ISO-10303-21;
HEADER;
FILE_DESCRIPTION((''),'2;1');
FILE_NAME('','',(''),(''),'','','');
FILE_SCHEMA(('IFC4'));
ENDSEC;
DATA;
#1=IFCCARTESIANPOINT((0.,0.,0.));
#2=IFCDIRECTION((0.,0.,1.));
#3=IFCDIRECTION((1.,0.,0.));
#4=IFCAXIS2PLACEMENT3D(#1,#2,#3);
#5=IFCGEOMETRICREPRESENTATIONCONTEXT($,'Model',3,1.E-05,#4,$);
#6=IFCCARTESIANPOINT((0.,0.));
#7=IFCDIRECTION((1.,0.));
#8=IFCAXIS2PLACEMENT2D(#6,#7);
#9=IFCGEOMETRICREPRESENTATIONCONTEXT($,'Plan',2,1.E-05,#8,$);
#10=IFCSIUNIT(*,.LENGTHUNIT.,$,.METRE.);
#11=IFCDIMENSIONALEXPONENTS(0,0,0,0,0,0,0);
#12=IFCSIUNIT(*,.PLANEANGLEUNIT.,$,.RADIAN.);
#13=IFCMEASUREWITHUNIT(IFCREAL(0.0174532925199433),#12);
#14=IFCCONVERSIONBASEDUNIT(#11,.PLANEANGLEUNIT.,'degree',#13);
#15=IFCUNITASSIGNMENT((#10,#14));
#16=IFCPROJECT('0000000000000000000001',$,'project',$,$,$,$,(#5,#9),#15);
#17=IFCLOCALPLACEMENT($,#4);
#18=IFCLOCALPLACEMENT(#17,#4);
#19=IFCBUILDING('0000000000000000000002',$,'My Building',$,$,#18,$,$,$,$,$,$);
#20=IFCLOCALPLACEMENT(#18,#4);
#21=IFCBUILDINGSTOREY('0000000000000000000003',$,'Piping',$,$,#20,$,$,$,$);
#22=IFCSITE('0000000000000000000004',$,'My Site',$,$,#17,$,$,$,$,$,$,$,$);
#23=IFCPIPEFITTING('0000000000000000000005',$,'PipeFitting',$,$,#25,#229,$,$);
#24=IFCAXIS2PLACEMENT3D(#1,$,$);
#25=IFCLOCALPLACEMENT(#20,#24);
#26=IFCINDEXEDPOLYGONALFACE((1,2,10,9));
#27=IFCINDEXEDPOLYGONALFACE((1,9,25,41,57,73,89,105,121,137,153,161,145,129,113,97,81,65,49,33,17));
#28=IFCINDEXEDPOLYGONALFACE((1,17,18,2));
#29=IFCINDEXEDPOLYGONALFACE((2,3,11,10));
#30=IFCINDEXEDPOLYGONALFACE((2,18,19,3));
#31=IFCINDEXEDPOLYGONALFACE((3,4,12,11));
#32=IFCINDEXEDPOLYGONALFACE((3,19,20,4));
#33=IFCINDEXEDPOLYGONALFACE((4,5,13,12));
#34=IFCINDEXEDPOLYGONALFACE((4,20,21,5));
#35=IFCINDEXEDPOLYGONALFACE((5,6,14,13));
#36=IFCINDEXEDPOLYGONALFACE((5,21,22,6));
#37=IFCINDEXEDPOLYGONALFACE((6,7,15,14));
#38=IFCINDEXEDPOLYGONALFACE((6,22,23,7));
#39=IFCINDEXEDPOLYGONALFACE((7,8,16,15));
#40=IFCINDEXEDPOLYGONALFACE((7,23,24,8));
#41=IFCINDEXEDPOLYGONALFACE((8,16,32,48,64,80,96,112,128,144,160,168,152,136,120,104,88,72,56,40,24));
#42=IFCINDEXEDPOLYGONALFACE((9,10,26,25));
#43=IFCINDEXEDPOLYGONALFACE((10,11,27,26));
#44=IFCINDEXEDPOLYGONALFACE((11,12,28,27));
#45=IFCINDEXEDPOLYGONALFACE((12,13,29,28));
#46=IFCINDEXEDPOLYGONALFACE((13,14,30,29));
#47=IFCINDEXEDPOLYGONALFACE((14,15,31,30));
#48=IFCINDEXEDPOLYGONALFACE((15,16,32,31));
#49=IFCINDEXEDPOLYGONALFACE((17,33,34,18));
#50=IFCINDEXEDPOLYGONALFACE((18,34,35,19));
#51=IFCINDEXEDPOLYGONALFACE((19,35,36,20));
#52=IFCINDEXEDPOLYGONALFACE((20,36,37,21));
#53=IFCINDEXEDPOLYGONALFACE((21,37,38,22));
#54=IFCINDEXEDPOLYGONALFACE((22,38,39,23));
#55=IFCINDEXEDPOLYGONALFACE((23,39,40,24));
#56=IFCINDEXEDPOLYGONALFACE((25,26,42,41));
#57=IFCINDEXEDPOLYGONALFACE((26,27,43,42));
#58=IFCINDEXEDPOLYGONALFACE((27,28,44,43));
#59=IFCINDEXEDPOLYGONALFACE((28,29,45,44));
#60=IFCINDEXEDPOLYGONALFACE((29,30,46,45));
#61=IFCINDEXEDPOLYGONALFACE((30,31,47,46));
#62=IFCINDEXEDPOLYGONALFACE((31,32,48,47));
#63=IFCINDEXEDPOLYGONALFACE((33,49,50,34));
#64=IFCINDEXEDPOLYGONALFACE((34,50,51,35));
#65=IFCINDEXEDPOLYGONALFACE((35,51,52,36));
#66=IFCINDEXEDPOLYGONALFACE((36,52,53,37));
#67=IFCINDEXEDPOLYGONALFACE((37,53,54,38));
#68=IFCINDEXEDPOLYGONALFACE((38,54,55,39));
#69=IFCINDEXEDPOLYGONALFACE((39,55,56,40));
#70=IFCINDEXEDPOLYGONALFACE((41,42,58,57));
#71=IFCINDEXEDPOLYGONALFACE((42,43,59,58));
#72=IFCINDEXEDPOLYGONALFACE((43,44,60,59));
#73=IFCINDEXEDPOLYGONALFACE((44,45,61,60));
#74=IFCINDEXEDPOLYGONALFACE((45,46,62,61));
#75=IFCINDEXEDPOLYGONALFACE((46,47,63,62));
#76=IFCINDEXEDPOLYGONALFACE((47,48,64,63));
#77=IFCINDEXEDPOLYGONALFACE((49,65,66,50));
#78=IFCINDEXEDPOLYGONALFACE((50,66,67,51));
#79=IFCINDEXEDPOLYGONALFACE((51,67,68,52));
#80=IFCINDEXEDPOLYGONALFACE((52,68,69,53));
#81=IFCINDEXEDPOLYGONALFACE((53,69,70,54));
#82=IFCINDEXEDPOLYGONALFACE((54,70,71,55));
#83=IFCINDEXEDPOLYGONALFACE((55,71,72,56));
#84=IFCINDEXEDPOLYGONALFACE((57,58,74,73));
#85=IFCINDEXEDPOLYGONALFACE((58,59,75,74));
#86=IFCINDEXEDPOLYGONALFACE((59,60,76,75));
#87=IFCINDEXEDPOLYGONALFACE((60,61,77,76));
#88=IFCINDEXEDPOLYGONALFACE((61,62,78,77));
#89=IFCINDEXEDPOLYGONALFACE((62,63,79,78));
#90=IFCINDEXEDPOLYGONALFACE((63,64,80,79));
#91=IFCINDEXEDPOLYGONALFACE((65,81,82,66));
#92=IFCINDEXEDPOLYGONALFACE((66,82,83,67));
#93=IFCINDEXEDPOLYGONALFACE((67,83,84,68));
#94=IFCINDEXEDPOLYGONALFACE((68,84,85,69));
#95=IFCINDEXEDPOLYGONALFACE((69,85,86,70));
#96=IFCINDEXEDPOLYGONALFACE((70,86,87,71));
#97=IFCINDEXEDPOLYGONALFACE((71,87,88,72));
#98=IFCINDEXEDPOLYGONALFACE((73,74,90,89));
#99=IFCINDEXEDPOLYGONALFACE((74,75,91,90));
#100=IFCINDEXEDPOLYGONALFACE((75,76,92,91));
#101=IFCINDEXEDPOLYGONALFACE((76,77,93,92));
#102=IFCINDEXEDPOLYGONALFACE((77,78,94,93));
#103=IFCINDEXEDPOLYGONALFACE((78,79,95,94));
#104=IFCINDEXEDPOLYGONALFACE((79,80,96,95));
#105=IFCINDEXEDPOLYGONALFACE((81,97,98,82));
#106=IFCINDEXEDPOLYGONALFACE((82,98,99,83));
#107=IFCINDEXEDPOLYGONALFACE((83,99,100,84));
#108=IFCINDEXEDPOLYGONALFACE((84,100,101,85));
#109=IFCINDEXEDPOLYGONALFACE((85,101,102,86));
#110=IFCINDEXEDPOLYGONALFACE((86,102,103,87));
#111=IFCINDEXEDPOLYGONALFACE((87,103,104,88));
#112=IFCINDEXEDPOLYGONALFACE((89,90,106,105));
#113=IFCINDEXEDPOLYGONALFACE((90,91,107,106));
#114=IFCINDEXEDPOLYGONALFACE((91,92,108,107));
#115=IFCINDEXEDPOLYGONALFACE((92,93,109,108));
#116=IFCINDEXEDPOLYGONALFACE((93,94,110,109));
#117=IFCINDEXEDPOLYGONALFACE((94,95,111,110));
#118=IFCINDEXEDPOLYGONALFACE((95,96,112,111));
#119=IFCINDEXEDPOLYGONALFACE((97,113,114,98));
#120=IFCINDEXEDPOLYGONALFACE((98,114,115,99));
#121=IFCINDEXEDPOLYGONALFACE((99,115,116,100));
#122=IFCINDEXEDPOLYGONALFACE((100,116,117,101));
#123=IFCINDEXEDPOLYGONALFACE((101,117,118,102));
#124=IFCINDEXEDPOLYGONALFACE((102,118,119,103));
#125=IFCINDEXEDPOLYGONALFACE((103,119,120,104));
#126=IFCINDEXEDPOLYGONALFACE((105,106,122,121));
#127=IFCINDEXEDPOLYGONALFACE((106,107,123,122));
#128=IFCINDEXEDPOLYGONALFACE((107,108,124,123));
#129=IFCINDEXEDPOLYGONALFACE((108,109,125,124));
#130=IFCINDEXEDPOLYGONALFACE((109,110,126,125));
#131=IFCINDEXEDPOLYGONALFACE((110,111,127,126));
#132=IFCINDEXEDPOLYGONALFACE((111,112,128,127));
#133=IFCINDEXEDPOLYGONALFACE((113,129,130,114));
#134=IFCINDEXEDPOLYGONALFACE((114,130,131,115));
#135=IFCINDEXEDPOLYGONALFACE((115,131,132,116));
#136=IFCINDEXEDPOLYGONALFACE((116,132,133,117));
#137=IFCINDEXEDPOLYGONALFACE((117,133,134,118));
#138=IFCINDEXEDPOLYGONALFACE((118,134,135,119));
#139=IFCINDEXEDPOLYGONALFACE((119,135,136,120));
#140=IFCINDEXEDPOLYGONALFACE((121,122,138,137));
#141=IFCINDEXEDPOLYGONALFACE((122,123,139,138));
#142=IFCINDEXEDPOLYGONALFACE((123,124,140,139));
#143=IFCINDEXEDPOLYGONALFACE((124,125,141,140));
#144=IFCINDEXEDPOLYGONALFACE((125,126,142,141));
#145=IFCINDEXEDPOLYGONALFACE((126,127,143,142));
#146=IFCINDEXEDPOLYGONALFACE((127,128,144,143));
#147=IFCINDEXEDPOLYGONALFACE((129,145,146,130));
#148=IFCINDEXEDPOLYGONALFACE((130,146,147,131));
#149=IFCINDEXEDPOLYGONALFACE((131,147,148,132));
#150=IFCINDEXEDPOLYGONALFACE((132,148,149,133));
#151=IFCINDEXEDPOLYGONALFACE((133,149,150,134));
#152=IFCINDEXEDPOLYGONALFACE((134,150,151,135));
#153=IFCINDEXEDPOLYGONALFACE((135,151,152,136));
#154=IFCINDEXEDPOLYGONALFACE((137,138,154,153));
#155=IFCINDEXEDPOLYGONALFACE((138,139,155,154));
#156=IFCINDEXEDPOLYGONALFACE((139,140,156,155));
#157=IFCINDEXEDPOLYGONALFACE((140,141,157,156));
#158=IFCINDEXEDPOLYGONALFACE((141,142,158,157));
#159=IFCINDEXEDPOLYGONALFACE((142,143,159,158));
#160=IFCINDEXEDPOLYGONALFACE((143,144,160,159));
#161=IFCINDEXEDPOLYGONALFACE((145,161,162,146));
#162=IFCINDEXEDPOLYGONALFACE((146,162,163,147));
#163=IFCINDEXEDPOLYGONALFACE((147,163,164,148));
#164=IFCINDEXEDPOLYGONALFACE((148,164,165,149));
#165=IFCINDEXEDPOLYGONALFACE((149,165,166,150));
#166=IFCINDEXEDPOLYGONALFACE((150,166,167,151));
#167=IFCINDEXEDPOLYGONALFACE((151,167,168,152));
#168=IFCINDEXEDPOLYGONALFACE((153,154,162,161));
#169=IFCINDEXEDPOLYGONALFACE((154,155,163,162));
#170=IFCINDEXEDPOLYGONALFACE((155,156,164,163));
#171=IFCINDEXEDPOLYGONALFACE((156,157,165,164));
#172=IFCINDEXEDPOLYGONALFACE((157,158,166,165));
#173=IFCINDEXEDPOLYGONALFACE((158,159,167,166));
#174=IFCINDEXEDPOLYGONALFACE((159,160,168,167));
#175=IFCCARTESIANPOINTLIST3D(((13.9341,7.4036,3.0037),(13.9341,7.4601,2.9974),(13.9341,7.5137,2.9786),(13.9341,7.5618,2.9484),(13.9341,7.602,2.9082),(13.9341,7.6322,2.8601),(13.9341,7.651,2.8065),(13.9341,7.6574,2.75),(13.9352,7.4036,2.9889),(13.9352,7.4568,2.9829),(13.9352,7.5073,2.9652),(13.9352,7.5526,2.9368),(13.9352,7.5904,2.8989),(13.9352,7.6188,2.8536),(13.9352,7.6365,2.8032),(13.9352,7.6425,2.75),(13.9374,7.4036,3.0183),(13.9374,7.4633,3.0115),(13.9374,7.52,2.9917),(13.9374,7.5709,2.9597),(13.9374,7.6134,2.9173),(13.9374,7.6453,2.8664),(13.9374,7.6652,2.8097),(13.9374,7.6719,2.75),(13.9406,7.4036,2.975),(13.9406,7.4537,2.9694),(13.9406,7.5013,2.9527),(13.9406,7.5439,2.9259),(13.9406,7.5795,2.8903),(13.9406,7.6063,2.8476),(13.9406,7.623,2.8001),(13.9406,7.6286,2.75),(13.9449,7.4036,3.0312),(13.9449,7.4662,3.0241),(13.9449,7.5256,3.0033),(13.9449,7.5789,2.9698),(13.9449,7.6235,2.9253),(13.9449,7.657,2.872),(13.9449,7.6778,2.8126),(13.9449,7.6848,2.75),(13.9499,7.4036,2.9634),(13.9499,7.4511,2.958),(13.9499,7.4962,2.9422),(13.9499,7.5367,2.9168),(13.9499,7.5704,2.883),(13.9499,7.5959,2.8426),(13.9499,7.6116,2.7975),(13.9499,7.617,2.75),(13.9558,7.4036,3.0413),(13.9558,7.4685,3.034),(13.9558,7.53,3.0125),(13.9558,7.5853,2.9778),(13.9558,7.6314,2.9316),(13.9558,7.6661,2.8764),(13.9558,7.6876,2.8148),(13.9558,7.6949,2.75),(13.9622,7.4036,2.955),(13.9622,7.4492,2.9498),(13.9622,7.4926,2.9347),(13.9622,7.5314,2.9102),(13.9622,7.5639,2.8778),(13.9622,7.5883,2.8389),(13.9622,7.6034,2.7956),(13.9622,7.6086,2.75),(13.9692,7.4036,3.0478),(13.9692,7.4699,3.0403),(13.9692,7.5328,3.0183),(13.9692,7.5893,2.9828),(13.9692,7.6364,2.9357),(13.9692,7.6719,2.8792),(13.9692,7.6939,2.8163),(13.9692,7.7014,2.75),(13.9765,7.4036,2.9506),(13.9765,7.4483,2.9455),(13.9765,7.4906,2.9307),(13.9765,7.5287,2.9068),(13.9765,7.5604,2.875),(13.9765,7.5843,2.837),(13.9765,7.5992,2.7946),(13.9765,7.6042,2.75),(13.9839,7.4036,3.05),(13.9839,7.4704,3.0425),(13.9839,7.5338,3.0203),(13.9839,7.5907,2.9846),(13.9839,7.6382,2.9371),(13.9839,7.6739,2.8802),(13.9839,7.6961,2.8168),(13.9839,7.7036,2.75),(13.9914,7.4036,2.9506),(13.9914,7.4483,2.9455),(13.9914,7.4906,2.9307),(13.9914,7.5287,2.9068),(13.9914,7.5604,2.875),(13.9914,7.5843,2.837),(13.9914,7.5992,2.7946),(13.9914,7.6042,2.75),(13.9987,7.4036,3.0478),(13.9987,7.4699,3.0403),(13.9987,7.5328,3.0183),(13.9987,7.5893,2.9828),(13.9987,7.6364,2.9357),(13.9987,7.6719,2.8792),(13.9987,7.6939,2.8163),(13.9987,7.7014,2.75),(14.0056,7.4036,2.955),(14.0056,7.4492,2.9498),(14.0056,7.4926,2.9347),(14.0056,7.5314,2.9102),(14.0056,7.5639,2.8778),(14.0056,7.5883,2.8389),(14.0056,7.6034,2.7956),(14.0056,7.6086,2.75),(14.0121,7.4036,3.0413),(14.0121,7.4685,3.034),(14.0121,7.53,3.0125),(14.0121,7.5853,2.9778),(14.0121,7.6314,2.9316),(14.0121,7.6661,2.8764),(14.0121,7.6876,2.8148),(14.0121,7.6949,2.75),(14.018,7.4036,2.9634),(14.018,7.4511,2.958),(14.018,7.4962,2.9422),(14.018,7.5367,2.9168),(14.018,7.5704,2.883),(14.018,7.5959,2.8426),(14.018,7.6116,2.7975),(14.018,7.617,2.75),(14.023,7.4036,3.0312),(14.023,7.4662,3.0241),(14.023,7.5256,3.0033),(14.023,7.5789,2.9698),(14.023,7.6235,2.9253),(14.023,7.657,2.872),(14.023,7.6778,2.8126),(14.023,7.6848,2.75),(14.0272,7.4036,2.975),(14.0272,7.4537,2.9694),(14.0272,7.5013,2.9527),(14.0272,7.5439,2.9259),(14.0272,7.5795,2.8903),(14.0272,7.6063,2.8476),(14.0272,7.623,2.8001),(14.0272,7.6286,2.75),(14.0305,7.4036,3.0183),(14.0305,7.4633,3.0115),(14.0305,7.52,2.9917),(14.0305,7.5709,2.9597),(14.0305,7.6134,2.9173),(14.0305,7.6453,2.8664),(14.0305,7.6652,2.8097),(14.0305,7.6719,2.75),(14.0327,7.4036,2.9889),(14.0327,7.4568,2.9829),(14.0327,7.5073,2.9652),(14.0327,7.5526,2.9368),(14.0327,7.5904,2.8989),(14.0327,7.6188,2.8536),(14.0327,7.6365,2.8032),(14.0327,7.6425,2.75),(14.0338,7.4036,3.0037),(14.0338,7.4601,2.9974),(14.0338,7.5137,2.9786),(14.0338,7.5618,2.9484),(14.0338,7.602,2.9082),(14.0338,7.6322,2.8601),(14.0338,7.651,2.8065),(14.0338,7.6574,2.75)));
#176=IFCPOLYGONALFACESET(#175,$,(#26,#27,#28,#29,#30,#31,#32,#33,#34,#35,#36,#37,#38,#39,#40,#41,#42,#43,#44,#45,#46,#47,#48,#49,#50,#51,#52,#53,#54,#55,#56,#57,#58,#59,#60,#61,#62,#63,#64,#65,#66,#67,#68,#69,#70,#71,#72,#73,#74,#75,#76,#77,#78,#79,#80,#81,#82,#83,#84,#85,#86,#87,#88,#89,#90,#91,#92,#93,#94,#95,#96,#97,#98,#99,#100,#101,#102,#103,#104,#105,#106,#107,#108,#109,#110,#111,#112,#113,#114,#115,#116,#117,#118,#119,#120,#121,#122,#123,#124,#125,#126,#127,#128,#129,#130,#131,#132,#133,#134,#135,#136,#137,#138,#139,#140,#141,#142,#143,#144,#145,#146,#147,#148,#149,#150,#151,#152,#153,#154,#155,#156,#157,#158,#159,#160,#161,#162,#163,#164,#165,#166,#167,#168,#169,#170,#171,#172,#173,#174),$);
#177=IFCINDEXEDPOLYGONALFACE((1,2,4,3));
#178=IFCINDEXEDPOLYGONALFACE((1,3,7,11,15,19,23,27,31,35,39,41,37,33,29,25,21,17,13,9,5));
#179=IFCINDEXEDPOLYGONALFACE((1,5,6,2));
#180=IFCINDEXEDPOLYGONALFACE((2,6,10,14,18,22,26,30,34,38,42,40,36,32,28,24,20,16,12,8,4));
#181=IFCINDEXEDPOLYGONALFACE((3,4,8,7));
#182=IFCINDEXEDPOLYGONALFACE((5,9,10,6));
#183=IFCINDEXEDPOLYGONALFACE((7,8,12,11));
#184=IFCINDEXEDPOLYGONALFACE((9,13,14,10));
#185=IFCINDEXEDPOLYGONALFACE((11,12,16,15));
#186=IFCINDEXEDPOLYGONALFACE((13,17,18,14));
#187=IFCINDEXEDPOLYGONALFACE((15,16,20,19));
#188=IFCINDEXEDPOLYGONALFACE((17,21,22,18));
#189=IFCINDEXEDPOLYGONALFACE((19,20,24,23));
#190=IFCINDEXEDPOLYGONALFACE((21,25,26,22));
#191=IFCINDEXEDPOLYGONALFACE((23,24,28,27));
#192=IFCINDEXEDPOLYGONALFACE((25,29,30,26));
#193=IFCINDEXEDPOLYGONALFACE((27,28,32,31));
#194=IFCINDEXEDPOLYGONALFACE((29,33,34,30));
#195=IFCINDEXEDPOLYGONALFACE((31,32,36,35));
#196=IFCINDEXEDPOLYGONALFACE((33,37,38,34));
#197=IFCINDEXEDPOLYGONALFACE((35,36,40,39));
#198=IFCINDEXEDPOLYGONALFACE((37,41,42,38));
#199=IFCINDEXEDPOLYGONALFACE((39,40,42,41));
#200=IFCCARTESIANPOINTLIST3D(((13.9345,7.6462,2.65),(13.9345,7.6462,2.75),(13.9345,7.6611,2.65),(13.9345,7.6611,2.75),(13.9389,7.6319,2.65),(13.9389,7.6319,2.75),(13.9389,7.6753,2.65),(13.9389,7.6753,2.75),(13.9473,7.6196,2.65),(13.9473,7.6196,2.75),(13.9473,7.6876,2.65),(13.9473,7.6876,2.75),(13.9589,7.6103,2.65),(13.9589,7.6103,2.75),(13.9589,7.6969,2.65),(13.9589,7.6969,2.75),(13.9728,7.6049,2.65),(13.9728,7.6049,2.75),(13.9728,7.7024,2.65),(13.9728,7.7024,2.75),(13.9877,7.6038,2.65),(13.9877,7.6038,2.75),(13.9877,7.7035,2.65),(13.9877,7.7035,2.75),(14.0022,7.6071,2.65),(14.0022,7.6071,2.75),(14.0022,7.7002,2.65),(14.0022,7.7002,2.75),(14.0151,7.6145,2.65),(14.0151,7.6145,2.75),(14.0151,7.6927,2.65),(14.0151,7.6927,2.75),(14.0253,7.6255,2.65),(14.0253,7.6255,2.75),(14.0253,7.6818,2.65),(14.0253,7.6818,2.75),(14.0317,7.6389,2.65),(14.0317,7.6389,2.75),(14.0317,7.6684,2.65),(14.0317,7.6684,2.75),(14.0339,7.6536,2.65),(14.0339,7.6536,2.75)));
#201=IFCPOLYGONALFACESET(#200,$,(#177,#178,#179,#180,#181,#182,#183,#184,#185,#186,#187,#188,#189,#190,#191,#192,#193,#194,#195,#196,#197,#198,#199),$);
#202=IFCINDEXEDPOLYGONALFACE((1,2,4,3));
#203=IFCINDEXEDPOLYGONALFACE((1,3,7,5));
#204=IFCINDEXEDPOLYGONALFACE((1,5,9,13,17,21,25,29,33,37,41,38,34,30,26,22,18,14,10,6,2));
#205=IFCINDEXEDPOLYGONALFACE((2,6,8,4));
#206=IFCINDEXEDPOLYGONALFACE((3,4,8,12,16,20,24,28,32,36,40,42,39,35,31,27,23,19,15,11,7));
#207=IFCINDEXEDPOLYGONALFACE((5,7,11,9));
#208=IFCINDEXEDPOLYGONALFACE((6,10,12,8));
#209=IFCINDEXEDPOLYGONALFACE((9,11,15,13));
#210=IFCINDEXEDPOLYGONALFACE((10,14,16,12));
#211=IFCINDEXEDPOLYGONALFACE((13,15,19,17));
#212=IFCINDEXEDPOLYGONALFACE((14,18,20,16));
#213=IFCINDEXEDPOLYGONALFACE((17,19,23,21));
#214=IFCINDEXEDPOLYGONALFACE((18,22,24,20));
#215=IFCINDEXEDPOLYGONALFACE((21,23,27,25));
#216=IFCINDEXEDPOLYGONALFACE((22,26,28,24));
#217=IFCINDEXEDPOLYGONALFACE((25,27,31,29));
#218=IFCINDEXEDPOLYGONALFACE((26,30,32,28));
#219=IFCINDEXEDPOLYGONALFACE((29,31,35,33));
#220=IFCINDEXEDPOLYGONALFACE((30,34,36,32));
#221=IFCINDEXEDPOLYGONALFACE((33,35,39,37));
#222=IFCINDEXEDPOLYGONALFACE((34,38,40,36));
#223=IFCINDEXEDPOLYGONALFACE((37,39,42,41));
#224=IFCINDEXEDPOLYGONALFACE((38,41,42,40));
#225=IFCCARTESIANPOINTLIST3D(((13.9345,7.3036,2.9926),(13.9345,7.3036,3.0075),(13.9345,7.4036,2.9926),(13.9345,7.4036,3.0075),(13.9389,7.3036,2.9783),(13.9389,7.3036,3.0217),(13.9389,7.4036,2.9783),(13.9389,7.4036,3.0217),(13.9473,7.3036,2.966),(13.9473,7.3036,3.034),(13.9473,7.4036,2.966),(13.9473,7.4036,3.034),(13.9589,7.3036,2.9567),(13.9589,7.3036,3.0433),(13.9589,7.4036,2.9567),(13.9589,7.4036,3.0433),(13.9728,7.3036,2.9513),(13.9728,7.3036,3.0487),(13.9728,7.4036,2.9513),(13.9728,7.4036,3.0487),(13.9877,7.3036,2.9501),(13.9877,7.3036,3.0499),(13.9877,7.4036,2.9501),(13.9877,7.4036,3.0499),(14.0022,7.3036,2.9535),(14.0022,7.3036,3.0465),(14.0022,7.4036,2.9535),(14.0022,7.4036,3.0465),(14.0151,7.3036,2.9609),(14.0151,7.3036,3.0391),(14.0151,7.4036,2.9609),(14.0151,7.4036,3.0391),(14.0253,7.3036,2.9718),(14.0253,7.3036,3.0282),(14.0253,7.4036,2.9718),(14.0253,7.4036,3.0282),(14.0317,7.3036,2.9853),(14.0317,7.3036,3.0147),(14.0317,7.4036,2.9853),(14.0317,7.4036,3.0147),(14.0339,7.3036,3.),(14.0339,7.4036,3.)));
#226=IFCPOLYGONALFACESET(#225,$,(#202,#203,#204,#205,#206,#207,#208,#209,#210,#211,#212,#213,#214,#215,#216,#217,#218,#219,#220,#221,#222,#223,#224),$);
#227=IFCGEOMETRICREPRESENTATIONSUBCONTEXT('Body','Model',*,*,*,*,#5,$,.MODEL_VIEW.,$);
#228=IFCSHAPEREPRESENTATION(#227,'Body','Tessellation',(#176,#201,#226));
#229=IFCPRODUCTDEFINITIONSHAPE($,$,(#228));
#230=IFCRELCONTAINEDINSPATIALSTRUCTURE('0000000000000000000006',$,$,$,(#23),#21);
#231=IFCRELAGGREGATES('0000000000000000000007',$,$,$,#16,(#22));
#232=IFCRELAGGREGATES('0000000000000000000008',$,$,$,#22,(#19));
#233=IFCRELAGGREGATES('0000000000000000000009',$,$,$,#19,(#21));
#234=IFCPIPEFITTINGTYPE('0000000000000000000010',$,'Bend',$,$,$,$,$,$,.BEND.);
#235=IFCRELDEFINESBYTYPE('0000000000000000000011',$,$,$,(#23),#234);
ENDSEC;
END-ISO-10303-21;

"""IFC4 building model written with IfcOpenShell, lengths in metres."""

from ifc_helpers import new_model, entity, si_unit, converted_unit, frame, origin_with_axes, origin_2d_with_axis, place, context, subcontext, project, spatial, circle, extrude, source, transform, mapped, type_object, type_shapes, element, save


model = new_model("IFC4")

# Units and contexts
model_context = context("Model", 3, precision=1e-05, world=origin_with_axes())
plan_context = context("Plan", 2, precision=1e-05, world=origin_2d_with_axis())
body_context = subcontext(model_context, "Body", "Model", "MODEL_VIEW")
ifc_project = project(units=[si_unit("LENGTHUNIT", "METRE"), converted_unit("PLANEANGLEUNIT", "degree", entity("IfcReal", 0.0174532925199433), si_unit("PLANEANGLEUNIT", "RADIAN"), dimensions=[0, 0, 0, 0, 0, 0, 0])], contexts=[model_context, plan_context])

# Site, building, storey
site_placement = place(None, origin_with_axes())
site = spatial("IfcSite", under=ifc_project, at=site_placement, Name="My Site")
building_placement = place(site_placement, origin_with_axes())
building = spatial("IfcBuilding", under=site, at=building_placement, Name="My Building")
storey_placement = place(building_placement, origin_with_axes())
storey = spatial("IfcBuildingStorey", under=building, at=storey_placement, Name="Piping")

# Pipe fitting
pipe_fitting_type = type_object("IfcPipeFittingType", Name="Bend", PredefinedType="BEND")
shared_shape = source(origin_with_axes(), body_context, "Body", "SolidModel", [
    entity("IfcSweptDiskSolid", entity("IfcIndexedPolyCurve", entity("IfcCartesianPointList3D", [[0.0, 0.0, -0.1], [0.0, 0.0732, -0.2768], [0.0, 0.25, -0.35]]), [entity("IfcArcIndex", [1, 2, 3])]), 0.05),
    extrude(circle(Radius=0.05), origin_with_axes(), (0.0, 0.0, -1.0), 0.1),
    extrude(circle(Radius=0.05), frame((0.0, 0.25, -0.35), z_axis=(0.0, 1.0, 0.0), x_axis=(1.0, 0.0, 0.0)), (0.0, 0.0, 1.0), 0.1),
])
type_shapes(pipe_fitting_type, [shared_shape])
for number, where, z_axis, x_axis, name in (
    (1, (13.9839, 7.6536, 2.65), (0.0, 0.0, -1.0), (1.0, 0.0, 0.0), "PipeFitting"),
):
    element("IfcPipeFitting", number, at=place(storey_placement, frame(where, z_axis=z_axis, x_axis=x_axis)), inside=storey, type_object=pipe_fitting_type, Name=name, context=body_context, shape_type="MappedRepresentation", body=[
        mapped(shared_shape, transform((0.0, 0.0, 0.0), x_axis=(1.0, 0.0, 0.0), y_axis=(0.0, 1.0, 0.0), z_axis=(0.0, 0.0, 1.0), scale=1.0)),
    ])

save(model, "model.ifc")
